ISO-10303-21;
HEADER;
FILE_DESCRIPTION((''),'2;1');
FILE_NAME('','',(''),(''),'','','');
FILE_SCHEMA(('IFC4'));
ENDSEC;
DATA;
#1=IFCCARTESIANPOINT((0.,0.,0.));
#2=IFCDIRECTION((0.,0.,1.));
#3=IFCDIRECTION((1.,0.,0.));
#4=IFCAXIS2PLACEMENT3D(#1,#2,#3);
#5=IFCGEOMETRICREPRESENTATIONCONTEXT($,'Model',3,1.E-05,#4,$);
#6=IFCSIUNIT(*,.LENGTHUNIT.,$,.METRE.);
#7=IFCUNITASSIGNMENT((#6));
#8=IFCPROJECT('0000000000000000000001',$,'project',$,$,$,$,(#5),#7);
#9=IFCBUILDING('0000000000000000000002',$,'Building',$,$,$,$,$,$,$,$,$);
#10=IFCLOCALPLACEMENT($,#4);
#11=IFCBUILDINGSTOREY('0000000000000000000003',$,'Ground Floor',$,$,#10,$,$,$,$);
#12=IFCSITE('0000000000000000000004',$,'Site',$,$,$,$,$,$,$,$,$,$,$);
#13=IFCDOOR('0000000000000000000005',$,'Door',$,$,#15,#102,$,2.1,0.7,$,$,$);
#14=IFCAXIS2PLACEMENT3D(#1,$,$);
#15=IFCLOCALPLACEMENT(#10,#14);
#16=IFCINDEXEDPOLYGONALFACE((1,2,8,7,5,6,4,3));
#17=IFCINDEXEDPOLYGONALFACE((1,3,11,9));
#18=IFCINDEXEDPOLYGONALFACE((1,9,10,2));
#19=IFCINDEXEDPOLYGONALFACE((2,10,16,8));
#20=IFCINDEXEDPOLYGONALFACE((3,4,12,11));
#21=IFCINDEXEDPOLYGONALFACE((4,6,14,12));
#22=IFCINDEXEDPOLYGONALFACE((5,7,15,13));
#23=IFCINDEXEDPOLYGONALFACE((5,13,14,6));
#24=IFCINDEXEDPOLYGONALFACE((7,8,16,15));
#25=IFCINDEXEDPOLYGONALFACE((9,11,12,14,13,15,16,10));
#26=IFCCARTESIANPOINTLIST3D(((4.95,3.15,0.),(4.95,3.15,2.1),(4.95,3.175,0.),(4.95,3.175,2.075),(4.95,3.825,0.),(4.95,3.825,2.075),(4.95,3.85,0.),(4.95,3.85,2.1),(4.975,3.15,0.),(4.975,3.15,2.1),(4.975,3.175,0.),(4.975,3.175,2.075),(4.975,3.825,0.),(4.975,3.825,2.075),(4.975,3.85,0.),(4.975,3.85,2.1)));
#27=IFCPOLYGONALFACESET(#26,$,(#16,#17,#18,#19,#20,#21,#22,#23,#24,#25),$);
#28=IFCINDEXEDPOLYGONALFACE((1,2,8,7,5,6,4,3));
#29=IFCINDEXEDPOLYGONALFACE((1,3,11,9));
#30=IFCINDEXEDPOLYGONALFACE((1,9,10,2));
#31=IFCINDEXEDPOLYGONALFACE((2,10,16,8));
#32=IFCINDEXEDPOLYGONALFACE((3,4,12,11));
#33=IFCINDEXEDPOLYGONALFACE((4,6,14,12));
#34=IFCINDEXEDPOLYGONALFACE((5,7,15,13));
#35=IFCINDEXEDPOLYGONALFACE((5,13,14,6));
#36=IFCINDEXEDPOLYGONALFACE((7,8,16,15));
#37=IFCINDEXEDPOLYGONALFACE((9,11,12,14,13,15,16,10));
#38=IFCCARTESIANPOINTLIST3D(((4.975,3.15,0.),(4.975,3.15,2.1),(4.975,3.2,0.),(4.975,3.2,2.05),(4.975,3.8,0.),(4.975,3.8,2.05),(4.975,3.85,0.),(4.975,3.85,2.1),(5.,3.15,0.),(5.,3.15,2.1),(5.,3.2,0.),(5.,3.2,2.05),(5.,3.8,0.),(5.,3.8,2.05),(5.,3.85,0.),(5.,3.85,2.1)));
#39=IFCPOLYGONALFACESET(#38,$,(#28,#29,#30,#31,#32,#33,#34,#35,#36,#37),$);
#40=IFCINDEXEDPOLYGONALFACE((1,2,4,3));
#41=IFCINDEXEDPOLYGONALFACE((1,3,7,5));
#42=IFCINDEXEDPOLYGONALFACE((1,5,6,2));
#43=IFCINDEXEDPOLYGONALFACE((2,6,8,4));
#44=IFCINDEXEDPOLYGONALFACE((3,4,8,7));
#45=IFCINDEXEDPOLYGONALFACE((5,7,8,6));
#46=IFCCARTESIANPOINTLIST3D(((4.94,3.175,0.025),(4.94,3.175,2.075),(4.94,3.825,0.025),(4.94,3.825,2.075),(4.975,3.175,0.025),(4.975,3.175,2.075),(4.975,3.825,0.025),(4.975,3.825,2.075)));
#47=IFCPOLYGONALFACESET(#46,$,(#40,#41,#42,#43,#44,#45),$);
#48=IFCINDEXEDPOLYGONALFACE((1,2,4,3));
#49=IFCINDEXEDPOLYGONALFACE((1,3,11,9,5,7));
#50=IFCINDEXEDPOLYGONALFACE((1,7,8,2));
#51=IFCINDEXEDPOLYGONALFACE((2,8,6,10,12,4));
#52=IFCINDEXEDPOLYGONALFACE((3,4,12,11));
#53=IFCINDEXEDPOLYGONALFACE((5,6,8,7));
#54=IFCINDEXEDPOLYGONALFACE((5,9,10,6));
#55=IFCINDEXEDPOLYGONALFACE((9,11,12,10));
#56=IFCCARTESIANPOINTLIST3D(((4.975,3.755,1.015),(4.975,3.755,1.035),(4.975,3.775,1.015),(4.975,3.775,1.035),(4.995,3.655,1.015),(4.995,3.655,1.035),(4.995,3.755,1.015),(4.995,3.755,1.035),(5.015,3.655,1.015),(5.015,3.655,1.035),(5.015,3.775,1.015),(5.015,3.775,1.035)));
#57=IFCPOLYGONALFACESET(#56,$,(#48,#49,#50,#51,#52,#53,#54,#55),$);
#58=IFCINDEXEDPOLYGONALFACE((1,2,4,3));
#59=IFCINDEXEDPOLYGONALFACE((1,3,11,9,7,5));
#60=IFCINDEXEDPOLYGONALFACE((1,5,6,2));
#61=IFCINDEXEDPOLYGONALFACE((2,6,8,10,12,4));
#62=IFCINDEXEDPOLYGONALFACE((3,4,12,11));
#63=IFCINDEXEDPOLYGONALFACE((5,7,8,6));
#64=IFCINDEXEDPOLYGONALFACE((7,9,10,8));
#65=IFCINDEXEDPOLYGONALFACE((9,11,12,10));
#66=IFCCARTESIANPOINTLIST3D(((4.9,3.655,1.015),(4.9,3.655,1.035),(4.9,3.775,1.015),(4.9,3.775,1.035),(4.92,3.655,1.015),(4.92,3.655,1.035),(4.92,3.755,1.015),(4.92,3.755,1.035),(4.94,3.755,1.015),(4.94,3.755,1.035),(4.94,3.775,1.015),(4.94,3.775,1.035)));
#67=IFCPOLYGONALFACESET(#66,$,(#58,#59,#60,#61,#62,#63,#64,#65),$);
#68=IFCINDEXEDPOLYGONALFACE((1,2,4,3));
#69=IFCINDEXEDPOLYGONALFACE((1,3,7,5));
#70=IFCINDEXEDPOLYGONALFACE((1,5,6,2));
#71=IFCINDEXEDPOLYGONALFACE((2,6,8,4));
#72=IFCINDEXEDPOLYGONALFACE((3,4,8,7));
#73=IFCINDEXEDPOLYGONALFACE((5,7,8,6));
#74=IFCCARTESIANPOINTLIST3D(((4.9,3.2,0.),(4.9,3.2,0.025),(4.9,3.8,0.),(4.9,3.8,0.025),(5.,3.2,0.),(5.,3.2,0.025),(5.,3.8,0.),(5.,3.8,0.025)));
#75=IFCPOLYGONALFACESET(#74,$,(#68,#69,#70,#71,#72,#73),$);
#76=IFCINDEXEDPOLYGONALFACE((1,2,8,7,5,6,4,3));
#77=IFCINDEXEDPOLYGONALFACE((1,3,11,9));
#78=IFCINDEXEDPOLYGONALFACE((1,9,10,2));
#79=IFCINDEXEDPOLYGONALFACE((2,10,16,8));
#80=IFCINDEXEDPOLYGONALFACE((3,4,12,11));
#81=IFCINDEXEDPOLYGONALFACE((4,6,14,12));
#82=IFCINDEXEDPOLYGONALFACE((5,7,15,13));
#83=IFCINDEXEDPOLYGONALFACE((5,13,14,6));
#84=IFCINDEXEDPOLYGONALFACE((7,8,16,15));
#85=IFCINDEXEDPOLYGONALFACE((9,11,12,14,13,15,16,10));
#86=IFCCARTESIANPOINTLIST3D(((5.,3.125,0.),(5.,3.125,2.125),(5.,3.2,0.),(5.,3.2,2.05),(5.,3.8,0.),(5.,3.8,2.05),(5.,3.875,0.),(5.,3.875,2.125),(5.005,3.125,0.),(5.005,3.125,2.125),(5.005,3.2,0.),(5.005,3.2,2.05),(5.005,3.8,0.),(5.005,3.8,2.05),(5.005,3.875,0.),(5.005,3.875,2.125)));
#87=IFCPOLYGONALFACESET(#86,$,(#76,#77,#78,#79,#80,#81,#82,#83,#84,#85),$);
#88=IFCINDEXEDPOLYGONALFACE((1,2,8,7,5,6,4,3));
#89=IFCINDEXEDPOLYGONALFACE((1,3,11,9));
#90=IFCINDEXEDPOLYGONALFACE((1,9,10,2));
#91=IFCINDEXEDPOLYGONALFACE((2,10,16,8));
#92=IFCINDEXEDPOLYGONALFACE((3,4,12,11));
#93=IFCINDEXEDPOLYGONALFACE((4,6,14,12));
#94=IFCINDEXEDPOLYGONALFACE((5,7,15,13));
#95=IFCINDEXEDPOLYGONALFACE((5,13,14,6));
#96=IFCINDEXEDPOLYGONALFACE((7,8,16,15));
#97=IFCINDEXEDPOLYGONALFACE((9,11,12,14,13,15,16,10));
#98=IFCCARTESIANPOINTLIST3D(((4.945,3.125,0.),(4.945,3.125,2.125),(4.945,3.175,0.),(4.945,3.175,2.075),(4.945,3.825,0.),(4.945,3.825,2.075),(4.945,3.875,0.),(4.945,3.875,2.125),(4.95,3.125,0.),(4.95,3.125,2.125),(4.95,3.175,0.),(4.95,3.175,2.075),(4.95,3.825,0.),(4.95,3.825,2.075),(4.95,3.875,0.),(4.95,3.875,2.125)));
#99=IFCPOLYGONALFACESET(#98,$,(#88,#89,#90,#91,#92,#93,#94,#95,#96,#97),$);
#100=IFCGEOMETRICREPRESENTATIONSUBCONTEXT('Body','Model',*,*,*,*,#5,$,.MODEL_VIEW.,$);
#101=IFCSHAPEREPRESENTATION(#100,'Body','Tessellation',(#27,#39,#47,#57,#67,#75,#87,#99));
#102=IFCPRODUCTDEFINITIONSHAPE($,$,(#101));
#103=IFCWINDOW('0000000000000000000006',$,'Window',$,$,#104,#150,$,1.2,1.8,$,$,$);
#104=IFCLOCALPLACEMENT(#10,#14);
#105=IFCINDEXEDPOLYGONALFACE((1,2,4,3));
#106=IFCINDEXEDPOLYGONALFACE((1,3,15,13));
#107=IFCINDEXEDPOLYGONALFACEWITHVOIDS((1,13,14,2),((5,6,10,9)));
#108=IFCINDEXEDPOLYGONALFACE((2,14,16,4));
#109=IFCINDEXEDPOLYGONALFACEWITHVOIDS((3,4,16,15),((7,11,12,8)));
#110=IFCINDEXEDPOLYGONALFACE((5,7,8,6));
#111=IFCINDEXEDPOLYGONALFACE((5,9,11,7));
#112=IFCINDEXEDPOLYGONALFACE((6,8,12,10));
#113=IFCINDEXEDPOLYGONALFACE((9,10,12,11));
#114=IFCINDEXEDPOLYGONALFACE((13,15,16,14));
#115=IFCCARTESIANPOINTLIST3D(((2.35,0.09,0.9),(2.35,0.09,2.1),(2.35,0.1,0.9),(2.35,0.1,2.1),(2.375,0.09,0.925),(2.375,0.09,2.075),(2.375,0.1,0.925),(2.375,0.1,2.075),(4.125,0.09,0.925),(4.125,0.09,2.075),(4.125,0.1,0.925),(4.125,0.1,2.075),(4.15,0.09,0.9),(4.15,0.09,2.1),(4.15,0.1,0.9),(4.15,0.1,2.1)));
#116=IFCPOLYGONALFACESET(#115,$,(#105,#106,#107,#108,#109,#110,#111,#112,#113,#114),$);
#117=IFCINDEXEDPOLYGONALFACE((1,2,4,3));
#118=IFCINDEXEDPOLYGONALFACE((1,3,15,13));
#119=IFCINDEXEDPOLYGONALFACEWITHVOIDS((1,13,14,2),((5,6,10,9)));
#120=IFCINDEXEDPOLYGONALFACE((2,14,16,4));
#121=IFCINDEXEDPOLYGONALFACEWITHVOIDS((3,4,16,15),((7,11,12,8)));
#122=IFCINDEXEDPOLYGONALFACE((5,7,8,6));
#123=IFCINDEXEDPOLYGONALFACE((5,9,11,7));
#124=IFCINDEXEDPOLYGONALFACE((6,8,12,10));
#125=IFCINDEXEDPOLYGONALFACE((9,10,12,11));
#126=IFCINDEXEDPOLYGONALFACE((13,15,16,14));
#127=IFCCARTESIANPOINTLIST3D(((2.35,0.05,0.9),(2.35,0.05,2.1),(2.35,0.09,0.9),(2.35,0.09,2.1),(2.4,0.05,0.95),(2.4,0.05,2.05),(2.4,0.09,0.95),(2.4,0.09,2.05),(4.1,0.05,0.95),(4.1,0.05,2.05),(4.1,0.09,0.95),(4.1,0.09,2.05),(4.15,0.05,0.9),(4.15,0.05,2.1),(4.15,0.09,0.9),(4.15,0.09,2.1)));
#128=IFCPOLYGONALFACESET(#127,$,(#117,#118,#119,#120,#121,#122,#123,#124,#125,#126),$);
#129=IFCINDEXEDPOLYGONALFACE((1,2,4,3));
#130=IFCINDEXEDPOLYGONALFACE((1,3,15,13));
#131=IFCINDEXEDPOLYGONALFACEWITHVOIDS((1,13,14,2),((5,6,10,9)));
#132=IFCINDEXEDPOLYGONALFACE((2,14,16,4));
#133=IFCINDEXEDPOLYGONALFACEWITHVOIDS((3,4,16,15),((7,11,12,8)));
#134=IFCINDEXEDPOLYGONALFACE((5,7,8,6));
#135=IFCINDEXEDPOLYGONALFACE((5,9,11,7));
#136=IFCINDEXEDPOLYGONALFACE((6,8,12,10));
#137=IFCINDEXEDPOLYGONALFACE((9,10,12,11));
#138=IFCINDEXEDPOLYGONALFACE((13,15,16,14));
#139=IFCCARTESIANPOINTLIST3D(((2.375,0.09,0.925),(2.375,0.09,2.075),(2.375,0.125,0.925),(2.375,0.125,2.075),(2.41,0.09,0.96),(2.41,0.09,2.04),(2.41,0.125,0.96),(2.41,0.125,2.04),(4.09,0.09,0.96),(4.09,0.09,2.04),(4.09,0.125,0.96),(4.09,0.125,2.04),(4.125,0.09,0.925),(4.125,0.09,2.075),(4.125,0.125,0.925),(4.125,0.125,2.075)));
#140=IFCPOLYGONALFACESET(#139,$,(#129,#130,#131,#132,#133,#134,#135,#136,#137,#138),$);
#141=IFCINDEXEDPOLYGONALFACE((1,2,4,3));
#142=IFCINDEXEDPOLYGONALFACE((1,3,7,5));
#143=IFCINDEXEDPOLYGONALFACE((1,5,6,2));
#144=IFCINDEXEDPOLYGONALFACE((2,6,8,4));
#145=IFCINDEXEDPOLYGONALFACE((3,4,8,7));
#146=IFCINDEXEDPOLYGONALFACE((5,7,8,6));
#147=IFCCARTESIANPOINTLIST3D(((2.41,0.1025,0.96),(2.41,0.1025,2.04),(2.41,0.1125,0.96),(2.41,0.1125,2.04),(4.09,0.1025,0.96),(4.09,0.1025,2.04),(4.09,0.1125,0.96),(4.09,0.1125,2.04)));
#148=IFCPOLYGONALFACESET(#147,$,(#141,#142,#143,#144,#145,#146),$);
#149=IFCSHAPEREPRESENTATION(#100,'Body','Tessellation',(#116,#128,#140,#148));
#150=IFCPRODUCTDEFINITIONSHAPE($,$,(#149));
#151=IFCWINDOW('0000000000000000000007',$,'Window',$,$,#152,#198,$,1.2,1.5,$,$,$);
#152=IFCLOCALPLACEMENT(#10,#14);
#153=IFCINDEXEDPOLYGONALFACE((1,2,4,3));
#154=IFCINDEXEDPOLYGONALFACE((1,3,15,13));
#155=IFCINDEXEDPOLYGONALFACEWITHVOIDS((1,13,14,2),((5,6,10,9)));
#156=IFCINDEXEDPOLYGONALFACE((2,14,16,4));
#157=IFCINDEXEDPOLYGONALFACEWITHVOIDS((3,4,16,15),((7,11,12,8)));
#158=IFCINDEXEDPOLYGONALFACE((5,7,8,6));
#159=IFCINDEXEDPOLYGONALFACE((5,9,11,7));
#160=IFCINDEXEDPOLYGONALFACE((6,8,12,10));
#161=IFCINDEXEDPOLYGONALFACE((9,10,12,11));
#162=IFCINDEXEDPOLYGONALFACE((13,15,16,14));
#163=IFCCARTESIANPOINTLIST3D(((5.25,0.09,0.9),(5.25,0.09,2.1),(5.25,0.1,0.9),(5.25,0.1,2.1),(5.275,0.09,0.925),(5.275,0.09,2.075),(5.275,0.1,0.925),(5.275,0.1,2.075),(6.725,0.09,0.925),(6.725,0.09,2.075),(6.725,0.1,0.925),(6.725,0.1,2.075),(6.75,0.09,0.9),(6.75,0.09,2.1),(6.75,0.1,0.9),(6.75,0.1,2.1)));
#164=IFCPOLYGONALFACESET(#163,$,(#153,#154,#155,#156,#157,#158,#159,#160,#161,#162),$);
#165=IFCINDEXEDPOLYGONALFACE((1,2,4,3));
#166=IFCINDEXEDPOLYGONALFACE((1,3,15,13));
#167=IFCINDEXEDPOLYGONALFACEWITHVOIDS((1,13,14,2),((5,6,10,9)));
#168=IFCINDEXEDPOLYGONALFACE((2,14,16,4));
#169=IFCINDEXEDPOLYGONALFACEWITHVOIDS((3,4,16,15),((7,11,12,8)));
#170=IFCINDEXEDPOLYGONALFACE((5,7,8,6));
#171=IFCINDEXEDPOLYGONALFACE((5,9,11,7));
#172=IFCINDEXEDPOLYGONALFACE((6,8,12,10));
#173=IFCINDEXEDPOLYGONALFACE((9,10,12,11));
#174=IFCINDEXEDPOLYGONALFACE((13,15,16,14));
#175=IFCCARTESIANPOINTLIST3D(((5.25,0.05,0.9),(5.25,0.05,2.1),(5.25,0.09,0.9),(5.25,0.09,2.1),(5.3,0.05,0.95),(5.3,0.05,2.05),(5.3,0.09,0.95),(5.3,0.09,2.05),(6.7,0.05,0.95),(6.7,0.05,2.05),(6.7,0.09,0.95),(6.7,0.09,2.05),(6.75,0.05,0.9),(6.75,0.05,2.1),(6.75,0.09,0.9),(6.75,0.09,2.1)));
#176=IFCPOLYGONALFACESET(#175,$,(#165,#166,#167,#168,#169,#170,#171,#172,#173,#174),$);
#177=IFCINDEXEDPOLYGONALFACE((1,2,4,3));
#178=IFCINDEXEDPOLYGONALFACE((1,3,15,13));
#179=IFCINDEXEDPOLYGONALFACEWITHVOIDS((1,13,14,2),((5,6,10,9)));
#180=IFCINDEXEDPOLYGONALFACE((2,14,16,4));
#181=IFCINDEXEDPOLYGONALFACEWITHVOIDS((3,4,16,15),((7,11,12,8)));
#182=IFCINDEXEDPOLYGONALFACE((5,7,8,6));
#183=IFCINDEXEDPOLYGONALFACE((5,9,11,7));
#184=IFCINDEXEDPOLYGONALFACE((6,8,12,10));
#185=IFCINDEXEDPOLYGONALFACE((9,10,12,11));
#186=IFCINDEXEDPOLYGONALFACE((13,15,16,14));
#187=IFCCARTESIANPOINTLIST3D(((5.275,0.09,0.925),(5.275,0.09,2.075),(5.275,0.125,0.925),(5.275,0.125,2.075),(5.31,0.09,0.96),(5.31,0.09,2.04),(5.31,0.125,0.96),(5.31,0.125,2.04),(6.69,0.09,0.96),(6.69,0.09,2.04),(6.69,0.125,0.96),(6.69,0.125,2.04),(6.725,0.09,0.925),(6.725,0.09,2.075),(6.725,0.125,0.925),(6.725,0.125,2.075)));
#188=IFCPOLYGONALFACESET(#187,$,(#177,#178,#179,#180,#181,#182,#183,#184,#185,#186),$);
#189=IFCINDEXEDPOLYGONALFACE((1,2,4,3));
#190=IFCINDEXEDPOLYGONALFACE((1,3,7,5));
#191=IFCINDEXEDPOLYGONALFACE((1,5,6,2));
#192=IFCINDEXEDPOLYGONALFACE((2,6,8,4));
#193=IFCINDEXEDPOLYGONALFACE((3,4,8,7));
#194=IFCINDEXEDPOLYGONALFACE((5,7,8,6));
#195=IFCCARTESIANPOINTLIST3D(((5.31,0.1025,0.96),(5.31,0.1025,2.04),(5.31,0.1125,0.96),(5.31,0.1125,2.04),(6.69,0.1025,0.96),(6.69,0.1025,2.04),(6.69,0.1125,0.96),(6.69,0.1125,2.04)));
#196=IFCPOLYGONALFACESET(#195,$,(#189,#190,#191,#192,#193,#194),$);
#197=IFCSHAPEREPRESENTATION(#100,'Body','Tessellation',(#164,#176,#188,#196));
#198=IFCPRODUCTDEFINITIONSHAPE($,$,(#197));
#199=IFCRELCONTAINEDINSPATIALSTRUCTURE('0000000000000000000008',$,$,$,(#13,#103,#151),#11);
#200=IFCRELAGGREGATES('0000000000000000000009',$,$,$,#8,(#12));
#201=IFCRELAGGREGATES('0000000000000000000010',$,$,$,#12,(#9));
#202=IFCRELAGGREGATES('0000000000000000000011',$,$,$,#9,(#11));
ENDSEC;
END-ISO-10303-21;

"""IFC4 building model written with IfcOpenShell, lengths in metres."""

from ifc_helpers import new_model, si_unit, frame, origin_with_axes, place, context, subcontext, project, spatial, line, indexed_curve, outline, extrude, element, save


model = new_model("IFC4")

# Units and contexts
model_context = context("Model", 3, precision=1e-05, world=origin_with_axes())
body_context = subcontext(model_context, "Body", "Model", "MODEL_VIEW")
ifc_project = project(units=[si_unit("LENGTHUNIT", "METRE")], contexts=[model_context])

# Site, building, storey
site = spatial("IfcSite", under=ifc_project, Name="Site")
building = spatial("IfcBuilding", under=site, Name="Building")
storey_placement = place(None, origin_with_axes())
storey = spatial("IfcBuildingStorey", under=building, at=storey_placement, Name="Ground Floor")

# Door
door_1_placement = place(storey_placement, frame((5.0, 3.15, 0.0), z_axis=(0.0, 0.0, 1.0), x_axis=(0.0, 1.0, 0.0)))
element("IfcDoor", 1, at=door_1_placement, inside=storey, Name="Door", OverallHeight=2.1, OverallWidth=0.7, context=body_context, shape_type="SweptSolid", body=[
    extrude(outline(indexed_curve([(0.0, 0.0), (0.0, 2.1), (0.7, 2.1), (0.7, 0.0), (0.675, 0.0), (0.675, 2.075), (0.025, 2.075), (0.025, 0.0)], segments=[line(1, 2, 3, 4, 5, 6, 7, 8, 1)])), frame((0.0, 0.025, 0.0), z_axis=(0.0, -1.0, 0.0), x_axis=(1.0, 0.0, 0.0)), (0.0, 0.0, -1.0), 0.025),
    extrude(outline(indexed_curve([(0.0, 0.0), (0.0, 2.1), (0.7, 2.1), (0.7, 0.0), (0.65, 0.0), (0.65, 2.05), (0.05, 2.05), (0.05, 0.0)], segments=[line(1, 2, 3, 4, 5, 6, 7, 8, 1)])), frame((0.0, 0.0, 0.0), z_axis=(0.0, -1.0, 0.0), x_axis=(1.0, 0.0, 0.0)), (0.0, 0.0, -1.0), 0.025),
    extrude(outline(indexed_curve([(0.0, 0.0), (0.65, 0.0), (0.65, 0.035), (0.0, 0.035)], segments=[line(1, 2, 3, 4, 1)])), frame((0.025, 0.025, 0.025), z_axis=(0.0, 0.0, 1.0), x_axis=(1.0, 0.0, 0.0)), (0.0, 0.0, 1.0), 2.05),
    extrude(outline(indexed_curve([(0.0, 0.0), (0.0, -0.04), (-0.12, -0.04), (-0.12, -0.02), (-0.02, -0.02), (-0.02, 0.0)], segments=[line(1, 2, 3, 4, 5, 6, 1)])), frame((0.625, 0.025, 1.015), z_axis=(0.0, 0.0, 1.0), x_axis=(1.0, 0.0, 0.0)), (0.0, 0.0, 1.0), 0.02),
    extrude(outline(indexed_curve([(0.0, 0.0), (0.0, 0.04), (-0.12, 0.04), (-0.12, 0.02), (-0.02, 0.02), (-0.02, 0.0)], segments=[line(1, 2, 3, 4, 5, 6, 1)])), frame((0.625, 0.06, 1.015), z_axis=(0.0, 0.0, 1.0), x_axis=(1.0, 0.0, 0.0)), (0.0, 0.0, 1.0), 0.02),
    extrude(outline(indexed_curve([(0.0, 0.0), (0.6, 0.0), (0.6, 0.1), (0.0, 0.1)], segments=[line(1, 2, 3, 4, 1)])), frame((0.05, 0.0, 0.0), z_axis=(0.0, 0.0, 1.0), x_axis=(1.0, 0.0, 0.0)), (0.0, 0.0, 1.0), 0.025),
    extrude(outline(indexed_curve([(0.0, 0.0), (0.0, 2.125), (0.75, 2.125), (0.75, 0.0), (0.675, 0.0), (0.675, 2.05), (0.075, 2.05), (0.075, 0.0)], segments=[line(1, 2, 3, 4, 5, 6, 7, 8, 1)])), frame((-0.025, -0.005, 0.0), z_axis=(0.0, -1.0, 0.0), x_axis=(1.0, 0.0, 0.0)), (0.0, 0.0, -1.0), 0.005),
    extrude(outline(indexed_curve([(0.0, 0.0), (0.0, 2.125), (0.75, 2.125), (0.75, 0.0), (0.7, 0.0), (0.7, 2.075), (0.05, 2.075), (0.05, 0.0)], segments=[line(1, 2, 3, 4, 5, 6, 7, 8, 1)])), frame((-0.025, 0.05, 0.0), z_axis=(0.0, -1.0, 0.0), x_axis=(1.0, 0.0, 0.0)), (0.0, 0.0, -1.0), 0.005),
])

# Windows
window_1_placement = place(storey_placement, frame((2.35, 0.0, 0.9), z_axis=(0.0, 0.0, 1.0), x_axis=(1.0, 0.0, 0.0)))
element("IfcWindow", 2, at=window_1_placement, inside=storey, Name="Window", OverallHeight=1.2, OverallWidth=1.8, context=body_context, shape_type="SweptSolid", body=[
    extrude(outline(indexed_curve([(0.0, 0.0), (1.8, 0.0), (1.8, 1.2), (0.0, 1.2)], segments=[line(1, 2, 3, 4, 1)]), holes=[indexed_curve([(0.025, 0.025), (1.775, 0.025), (1.775, 1.175), (0.025, 1.175)], segments=[line(1, 2, 3, 4, 1)])]), frame((0.0, 0.09, 0.0), z_axis=(0.0, -1.0, 0.0), x_axis=(1.0, 0.0, 0.0)), (0.0, 0.0, -1.0), 0.01),
    extrude(outline(indexed_curve([(0.0, 0.0), (1.8, 0.0), (1.8, 1.2), (0.0, 1.2)], segments=[line(1, 2, 3, 4, 1)]), holes=[indexed_curve([(0.05, 0.05), (1.75, 0.05), (1.75, 1.15), (0.05, 1.15)], segments=[line(1, 2, 3, 4, 1)])]), frame((0.0, 0.05, 0.0), z_axis=(0.0, -1.0, 0.0), x_axis=(1.0, 0.0, 0.0)), (0.0, 0.0, -1.0), 0.04),
    extrude(outline(indexed_curve([(0.0, 0.0), (1.75, 0.0), (1.75, 1.15), (0.0, 1.15)], segments=[line(1, 2, 3, 4, 1)]), holes=[indexed_curve([(0.035, 0.035), (1.715, 0.035), (1.715, 1.115), (0.035, 1.115)], segments=[line(1, 2, 3, 4, 1)])]), frame((0.025, 0.09, 0.025), z_axis=(0.0, -1.0, 0.0), x_axis=(1.0, 0.0, 0.0)), (0.0, 0.0, -1.0), 0.035),
    extrude(outline(indexed_curve([(0.035, 0.035), (1.715, 0.035), (1.715, 1.115), (0.035, 1.115)], segments=[line(1, 2, 3, 4, 1)])), frame((0.025, 0.1025, 0.025), z_axis=(0.0, -1.0, 0.0), x_axis=(1.0, 0.0, 0.0)), (0.0, 0.0, -1.0), 0.01),
])
window_2_placement = place(storey_placement, frame((5.25, 0.0, 0.9), z_axis=(0.0, 0.0, 1.0), x_axis=(1.0, 0.0, 0.0)))
element("IfcWindow", 3, at=window_2_placement, inside=storey, Name="Window", OverallHeight=1.2, OverallWidth=1.5, context=body_context, shape_type="SweptSolid", body=[
    extrude(outline(indexed_curve([(0.0, 0.0), (1.5, 0.0), (1.5, 1.2), (0.0, 1.2)], segments=[line(1, 2, 3, 4, 1)]), holes=[indexed_curve([(0.025, 0.025), (1.475, 0.025), (1.475, 1.175), (0.025, 1.175)], segments=[line(1, 2, 3, 4, 1)])]), frame((0.0, 0.09, 0.0), z_axis=(0.0, -1.0, 0.0), x_axis=(1.0, 0.0, 0.0)), (0.0, 0.0, -1.0), 0.01),
    extrude(outline(indexed_curve([(0.0, 0.0), (1.5, 0.0), (1.5, 1.2), (0.0, 1.2)], segments=[line(1, 2, 3, 4, 1)]), holes=[indexed_curve([(0.05, 0.05), (1.45, 0.05), (1.45, 1.15), (0.05, 1.15)], segments=[line(1, 2, 3, 4, 1)])]), frame((0.0, 0.05, 0.0), z_axis=(0.0, -1.0, 0.0), x_axis=(1.0, 0.0, 0.0)), (0.0, 0.0, -1.0), 0.04),
    extrude(outline(indexed_curve([(0.0, 0.0), (1.45, 0.0), (1.45, 1.15), (0.0, 1.15)], segments=[line(1, 2, 3, 4, 1)]), holes=[indexed_curve([(0.035, 0.035), (1.415, 0.035), (1.415, 1.115), (0.035, 1.115)], segments=[line(1, 2, 3, 4, 1)])]), frame((0.025, 0.09, 0.025), z_axis=(0.0, -1.0, 0.0), x_axis=(1.0, 0.0, 0.0)), (0.0, 0.0, -1.0), 0.035),
    extrude(outline(indexed_curve([(0.035, 0.035), (1.415, 0.035), (1.415, 1.115), (0.035, 1.115)], segments=[line(1, 2, 3, 4, 1)])), frame((0.025, 0.1025, 0.025), z_axis=(0.0, -1.0, 0.0), x_axis=(1.0, 0.0, 0.0)), (0.0, 0.0, -1.0), 0.01),
])

save(model, "model.ifc")
